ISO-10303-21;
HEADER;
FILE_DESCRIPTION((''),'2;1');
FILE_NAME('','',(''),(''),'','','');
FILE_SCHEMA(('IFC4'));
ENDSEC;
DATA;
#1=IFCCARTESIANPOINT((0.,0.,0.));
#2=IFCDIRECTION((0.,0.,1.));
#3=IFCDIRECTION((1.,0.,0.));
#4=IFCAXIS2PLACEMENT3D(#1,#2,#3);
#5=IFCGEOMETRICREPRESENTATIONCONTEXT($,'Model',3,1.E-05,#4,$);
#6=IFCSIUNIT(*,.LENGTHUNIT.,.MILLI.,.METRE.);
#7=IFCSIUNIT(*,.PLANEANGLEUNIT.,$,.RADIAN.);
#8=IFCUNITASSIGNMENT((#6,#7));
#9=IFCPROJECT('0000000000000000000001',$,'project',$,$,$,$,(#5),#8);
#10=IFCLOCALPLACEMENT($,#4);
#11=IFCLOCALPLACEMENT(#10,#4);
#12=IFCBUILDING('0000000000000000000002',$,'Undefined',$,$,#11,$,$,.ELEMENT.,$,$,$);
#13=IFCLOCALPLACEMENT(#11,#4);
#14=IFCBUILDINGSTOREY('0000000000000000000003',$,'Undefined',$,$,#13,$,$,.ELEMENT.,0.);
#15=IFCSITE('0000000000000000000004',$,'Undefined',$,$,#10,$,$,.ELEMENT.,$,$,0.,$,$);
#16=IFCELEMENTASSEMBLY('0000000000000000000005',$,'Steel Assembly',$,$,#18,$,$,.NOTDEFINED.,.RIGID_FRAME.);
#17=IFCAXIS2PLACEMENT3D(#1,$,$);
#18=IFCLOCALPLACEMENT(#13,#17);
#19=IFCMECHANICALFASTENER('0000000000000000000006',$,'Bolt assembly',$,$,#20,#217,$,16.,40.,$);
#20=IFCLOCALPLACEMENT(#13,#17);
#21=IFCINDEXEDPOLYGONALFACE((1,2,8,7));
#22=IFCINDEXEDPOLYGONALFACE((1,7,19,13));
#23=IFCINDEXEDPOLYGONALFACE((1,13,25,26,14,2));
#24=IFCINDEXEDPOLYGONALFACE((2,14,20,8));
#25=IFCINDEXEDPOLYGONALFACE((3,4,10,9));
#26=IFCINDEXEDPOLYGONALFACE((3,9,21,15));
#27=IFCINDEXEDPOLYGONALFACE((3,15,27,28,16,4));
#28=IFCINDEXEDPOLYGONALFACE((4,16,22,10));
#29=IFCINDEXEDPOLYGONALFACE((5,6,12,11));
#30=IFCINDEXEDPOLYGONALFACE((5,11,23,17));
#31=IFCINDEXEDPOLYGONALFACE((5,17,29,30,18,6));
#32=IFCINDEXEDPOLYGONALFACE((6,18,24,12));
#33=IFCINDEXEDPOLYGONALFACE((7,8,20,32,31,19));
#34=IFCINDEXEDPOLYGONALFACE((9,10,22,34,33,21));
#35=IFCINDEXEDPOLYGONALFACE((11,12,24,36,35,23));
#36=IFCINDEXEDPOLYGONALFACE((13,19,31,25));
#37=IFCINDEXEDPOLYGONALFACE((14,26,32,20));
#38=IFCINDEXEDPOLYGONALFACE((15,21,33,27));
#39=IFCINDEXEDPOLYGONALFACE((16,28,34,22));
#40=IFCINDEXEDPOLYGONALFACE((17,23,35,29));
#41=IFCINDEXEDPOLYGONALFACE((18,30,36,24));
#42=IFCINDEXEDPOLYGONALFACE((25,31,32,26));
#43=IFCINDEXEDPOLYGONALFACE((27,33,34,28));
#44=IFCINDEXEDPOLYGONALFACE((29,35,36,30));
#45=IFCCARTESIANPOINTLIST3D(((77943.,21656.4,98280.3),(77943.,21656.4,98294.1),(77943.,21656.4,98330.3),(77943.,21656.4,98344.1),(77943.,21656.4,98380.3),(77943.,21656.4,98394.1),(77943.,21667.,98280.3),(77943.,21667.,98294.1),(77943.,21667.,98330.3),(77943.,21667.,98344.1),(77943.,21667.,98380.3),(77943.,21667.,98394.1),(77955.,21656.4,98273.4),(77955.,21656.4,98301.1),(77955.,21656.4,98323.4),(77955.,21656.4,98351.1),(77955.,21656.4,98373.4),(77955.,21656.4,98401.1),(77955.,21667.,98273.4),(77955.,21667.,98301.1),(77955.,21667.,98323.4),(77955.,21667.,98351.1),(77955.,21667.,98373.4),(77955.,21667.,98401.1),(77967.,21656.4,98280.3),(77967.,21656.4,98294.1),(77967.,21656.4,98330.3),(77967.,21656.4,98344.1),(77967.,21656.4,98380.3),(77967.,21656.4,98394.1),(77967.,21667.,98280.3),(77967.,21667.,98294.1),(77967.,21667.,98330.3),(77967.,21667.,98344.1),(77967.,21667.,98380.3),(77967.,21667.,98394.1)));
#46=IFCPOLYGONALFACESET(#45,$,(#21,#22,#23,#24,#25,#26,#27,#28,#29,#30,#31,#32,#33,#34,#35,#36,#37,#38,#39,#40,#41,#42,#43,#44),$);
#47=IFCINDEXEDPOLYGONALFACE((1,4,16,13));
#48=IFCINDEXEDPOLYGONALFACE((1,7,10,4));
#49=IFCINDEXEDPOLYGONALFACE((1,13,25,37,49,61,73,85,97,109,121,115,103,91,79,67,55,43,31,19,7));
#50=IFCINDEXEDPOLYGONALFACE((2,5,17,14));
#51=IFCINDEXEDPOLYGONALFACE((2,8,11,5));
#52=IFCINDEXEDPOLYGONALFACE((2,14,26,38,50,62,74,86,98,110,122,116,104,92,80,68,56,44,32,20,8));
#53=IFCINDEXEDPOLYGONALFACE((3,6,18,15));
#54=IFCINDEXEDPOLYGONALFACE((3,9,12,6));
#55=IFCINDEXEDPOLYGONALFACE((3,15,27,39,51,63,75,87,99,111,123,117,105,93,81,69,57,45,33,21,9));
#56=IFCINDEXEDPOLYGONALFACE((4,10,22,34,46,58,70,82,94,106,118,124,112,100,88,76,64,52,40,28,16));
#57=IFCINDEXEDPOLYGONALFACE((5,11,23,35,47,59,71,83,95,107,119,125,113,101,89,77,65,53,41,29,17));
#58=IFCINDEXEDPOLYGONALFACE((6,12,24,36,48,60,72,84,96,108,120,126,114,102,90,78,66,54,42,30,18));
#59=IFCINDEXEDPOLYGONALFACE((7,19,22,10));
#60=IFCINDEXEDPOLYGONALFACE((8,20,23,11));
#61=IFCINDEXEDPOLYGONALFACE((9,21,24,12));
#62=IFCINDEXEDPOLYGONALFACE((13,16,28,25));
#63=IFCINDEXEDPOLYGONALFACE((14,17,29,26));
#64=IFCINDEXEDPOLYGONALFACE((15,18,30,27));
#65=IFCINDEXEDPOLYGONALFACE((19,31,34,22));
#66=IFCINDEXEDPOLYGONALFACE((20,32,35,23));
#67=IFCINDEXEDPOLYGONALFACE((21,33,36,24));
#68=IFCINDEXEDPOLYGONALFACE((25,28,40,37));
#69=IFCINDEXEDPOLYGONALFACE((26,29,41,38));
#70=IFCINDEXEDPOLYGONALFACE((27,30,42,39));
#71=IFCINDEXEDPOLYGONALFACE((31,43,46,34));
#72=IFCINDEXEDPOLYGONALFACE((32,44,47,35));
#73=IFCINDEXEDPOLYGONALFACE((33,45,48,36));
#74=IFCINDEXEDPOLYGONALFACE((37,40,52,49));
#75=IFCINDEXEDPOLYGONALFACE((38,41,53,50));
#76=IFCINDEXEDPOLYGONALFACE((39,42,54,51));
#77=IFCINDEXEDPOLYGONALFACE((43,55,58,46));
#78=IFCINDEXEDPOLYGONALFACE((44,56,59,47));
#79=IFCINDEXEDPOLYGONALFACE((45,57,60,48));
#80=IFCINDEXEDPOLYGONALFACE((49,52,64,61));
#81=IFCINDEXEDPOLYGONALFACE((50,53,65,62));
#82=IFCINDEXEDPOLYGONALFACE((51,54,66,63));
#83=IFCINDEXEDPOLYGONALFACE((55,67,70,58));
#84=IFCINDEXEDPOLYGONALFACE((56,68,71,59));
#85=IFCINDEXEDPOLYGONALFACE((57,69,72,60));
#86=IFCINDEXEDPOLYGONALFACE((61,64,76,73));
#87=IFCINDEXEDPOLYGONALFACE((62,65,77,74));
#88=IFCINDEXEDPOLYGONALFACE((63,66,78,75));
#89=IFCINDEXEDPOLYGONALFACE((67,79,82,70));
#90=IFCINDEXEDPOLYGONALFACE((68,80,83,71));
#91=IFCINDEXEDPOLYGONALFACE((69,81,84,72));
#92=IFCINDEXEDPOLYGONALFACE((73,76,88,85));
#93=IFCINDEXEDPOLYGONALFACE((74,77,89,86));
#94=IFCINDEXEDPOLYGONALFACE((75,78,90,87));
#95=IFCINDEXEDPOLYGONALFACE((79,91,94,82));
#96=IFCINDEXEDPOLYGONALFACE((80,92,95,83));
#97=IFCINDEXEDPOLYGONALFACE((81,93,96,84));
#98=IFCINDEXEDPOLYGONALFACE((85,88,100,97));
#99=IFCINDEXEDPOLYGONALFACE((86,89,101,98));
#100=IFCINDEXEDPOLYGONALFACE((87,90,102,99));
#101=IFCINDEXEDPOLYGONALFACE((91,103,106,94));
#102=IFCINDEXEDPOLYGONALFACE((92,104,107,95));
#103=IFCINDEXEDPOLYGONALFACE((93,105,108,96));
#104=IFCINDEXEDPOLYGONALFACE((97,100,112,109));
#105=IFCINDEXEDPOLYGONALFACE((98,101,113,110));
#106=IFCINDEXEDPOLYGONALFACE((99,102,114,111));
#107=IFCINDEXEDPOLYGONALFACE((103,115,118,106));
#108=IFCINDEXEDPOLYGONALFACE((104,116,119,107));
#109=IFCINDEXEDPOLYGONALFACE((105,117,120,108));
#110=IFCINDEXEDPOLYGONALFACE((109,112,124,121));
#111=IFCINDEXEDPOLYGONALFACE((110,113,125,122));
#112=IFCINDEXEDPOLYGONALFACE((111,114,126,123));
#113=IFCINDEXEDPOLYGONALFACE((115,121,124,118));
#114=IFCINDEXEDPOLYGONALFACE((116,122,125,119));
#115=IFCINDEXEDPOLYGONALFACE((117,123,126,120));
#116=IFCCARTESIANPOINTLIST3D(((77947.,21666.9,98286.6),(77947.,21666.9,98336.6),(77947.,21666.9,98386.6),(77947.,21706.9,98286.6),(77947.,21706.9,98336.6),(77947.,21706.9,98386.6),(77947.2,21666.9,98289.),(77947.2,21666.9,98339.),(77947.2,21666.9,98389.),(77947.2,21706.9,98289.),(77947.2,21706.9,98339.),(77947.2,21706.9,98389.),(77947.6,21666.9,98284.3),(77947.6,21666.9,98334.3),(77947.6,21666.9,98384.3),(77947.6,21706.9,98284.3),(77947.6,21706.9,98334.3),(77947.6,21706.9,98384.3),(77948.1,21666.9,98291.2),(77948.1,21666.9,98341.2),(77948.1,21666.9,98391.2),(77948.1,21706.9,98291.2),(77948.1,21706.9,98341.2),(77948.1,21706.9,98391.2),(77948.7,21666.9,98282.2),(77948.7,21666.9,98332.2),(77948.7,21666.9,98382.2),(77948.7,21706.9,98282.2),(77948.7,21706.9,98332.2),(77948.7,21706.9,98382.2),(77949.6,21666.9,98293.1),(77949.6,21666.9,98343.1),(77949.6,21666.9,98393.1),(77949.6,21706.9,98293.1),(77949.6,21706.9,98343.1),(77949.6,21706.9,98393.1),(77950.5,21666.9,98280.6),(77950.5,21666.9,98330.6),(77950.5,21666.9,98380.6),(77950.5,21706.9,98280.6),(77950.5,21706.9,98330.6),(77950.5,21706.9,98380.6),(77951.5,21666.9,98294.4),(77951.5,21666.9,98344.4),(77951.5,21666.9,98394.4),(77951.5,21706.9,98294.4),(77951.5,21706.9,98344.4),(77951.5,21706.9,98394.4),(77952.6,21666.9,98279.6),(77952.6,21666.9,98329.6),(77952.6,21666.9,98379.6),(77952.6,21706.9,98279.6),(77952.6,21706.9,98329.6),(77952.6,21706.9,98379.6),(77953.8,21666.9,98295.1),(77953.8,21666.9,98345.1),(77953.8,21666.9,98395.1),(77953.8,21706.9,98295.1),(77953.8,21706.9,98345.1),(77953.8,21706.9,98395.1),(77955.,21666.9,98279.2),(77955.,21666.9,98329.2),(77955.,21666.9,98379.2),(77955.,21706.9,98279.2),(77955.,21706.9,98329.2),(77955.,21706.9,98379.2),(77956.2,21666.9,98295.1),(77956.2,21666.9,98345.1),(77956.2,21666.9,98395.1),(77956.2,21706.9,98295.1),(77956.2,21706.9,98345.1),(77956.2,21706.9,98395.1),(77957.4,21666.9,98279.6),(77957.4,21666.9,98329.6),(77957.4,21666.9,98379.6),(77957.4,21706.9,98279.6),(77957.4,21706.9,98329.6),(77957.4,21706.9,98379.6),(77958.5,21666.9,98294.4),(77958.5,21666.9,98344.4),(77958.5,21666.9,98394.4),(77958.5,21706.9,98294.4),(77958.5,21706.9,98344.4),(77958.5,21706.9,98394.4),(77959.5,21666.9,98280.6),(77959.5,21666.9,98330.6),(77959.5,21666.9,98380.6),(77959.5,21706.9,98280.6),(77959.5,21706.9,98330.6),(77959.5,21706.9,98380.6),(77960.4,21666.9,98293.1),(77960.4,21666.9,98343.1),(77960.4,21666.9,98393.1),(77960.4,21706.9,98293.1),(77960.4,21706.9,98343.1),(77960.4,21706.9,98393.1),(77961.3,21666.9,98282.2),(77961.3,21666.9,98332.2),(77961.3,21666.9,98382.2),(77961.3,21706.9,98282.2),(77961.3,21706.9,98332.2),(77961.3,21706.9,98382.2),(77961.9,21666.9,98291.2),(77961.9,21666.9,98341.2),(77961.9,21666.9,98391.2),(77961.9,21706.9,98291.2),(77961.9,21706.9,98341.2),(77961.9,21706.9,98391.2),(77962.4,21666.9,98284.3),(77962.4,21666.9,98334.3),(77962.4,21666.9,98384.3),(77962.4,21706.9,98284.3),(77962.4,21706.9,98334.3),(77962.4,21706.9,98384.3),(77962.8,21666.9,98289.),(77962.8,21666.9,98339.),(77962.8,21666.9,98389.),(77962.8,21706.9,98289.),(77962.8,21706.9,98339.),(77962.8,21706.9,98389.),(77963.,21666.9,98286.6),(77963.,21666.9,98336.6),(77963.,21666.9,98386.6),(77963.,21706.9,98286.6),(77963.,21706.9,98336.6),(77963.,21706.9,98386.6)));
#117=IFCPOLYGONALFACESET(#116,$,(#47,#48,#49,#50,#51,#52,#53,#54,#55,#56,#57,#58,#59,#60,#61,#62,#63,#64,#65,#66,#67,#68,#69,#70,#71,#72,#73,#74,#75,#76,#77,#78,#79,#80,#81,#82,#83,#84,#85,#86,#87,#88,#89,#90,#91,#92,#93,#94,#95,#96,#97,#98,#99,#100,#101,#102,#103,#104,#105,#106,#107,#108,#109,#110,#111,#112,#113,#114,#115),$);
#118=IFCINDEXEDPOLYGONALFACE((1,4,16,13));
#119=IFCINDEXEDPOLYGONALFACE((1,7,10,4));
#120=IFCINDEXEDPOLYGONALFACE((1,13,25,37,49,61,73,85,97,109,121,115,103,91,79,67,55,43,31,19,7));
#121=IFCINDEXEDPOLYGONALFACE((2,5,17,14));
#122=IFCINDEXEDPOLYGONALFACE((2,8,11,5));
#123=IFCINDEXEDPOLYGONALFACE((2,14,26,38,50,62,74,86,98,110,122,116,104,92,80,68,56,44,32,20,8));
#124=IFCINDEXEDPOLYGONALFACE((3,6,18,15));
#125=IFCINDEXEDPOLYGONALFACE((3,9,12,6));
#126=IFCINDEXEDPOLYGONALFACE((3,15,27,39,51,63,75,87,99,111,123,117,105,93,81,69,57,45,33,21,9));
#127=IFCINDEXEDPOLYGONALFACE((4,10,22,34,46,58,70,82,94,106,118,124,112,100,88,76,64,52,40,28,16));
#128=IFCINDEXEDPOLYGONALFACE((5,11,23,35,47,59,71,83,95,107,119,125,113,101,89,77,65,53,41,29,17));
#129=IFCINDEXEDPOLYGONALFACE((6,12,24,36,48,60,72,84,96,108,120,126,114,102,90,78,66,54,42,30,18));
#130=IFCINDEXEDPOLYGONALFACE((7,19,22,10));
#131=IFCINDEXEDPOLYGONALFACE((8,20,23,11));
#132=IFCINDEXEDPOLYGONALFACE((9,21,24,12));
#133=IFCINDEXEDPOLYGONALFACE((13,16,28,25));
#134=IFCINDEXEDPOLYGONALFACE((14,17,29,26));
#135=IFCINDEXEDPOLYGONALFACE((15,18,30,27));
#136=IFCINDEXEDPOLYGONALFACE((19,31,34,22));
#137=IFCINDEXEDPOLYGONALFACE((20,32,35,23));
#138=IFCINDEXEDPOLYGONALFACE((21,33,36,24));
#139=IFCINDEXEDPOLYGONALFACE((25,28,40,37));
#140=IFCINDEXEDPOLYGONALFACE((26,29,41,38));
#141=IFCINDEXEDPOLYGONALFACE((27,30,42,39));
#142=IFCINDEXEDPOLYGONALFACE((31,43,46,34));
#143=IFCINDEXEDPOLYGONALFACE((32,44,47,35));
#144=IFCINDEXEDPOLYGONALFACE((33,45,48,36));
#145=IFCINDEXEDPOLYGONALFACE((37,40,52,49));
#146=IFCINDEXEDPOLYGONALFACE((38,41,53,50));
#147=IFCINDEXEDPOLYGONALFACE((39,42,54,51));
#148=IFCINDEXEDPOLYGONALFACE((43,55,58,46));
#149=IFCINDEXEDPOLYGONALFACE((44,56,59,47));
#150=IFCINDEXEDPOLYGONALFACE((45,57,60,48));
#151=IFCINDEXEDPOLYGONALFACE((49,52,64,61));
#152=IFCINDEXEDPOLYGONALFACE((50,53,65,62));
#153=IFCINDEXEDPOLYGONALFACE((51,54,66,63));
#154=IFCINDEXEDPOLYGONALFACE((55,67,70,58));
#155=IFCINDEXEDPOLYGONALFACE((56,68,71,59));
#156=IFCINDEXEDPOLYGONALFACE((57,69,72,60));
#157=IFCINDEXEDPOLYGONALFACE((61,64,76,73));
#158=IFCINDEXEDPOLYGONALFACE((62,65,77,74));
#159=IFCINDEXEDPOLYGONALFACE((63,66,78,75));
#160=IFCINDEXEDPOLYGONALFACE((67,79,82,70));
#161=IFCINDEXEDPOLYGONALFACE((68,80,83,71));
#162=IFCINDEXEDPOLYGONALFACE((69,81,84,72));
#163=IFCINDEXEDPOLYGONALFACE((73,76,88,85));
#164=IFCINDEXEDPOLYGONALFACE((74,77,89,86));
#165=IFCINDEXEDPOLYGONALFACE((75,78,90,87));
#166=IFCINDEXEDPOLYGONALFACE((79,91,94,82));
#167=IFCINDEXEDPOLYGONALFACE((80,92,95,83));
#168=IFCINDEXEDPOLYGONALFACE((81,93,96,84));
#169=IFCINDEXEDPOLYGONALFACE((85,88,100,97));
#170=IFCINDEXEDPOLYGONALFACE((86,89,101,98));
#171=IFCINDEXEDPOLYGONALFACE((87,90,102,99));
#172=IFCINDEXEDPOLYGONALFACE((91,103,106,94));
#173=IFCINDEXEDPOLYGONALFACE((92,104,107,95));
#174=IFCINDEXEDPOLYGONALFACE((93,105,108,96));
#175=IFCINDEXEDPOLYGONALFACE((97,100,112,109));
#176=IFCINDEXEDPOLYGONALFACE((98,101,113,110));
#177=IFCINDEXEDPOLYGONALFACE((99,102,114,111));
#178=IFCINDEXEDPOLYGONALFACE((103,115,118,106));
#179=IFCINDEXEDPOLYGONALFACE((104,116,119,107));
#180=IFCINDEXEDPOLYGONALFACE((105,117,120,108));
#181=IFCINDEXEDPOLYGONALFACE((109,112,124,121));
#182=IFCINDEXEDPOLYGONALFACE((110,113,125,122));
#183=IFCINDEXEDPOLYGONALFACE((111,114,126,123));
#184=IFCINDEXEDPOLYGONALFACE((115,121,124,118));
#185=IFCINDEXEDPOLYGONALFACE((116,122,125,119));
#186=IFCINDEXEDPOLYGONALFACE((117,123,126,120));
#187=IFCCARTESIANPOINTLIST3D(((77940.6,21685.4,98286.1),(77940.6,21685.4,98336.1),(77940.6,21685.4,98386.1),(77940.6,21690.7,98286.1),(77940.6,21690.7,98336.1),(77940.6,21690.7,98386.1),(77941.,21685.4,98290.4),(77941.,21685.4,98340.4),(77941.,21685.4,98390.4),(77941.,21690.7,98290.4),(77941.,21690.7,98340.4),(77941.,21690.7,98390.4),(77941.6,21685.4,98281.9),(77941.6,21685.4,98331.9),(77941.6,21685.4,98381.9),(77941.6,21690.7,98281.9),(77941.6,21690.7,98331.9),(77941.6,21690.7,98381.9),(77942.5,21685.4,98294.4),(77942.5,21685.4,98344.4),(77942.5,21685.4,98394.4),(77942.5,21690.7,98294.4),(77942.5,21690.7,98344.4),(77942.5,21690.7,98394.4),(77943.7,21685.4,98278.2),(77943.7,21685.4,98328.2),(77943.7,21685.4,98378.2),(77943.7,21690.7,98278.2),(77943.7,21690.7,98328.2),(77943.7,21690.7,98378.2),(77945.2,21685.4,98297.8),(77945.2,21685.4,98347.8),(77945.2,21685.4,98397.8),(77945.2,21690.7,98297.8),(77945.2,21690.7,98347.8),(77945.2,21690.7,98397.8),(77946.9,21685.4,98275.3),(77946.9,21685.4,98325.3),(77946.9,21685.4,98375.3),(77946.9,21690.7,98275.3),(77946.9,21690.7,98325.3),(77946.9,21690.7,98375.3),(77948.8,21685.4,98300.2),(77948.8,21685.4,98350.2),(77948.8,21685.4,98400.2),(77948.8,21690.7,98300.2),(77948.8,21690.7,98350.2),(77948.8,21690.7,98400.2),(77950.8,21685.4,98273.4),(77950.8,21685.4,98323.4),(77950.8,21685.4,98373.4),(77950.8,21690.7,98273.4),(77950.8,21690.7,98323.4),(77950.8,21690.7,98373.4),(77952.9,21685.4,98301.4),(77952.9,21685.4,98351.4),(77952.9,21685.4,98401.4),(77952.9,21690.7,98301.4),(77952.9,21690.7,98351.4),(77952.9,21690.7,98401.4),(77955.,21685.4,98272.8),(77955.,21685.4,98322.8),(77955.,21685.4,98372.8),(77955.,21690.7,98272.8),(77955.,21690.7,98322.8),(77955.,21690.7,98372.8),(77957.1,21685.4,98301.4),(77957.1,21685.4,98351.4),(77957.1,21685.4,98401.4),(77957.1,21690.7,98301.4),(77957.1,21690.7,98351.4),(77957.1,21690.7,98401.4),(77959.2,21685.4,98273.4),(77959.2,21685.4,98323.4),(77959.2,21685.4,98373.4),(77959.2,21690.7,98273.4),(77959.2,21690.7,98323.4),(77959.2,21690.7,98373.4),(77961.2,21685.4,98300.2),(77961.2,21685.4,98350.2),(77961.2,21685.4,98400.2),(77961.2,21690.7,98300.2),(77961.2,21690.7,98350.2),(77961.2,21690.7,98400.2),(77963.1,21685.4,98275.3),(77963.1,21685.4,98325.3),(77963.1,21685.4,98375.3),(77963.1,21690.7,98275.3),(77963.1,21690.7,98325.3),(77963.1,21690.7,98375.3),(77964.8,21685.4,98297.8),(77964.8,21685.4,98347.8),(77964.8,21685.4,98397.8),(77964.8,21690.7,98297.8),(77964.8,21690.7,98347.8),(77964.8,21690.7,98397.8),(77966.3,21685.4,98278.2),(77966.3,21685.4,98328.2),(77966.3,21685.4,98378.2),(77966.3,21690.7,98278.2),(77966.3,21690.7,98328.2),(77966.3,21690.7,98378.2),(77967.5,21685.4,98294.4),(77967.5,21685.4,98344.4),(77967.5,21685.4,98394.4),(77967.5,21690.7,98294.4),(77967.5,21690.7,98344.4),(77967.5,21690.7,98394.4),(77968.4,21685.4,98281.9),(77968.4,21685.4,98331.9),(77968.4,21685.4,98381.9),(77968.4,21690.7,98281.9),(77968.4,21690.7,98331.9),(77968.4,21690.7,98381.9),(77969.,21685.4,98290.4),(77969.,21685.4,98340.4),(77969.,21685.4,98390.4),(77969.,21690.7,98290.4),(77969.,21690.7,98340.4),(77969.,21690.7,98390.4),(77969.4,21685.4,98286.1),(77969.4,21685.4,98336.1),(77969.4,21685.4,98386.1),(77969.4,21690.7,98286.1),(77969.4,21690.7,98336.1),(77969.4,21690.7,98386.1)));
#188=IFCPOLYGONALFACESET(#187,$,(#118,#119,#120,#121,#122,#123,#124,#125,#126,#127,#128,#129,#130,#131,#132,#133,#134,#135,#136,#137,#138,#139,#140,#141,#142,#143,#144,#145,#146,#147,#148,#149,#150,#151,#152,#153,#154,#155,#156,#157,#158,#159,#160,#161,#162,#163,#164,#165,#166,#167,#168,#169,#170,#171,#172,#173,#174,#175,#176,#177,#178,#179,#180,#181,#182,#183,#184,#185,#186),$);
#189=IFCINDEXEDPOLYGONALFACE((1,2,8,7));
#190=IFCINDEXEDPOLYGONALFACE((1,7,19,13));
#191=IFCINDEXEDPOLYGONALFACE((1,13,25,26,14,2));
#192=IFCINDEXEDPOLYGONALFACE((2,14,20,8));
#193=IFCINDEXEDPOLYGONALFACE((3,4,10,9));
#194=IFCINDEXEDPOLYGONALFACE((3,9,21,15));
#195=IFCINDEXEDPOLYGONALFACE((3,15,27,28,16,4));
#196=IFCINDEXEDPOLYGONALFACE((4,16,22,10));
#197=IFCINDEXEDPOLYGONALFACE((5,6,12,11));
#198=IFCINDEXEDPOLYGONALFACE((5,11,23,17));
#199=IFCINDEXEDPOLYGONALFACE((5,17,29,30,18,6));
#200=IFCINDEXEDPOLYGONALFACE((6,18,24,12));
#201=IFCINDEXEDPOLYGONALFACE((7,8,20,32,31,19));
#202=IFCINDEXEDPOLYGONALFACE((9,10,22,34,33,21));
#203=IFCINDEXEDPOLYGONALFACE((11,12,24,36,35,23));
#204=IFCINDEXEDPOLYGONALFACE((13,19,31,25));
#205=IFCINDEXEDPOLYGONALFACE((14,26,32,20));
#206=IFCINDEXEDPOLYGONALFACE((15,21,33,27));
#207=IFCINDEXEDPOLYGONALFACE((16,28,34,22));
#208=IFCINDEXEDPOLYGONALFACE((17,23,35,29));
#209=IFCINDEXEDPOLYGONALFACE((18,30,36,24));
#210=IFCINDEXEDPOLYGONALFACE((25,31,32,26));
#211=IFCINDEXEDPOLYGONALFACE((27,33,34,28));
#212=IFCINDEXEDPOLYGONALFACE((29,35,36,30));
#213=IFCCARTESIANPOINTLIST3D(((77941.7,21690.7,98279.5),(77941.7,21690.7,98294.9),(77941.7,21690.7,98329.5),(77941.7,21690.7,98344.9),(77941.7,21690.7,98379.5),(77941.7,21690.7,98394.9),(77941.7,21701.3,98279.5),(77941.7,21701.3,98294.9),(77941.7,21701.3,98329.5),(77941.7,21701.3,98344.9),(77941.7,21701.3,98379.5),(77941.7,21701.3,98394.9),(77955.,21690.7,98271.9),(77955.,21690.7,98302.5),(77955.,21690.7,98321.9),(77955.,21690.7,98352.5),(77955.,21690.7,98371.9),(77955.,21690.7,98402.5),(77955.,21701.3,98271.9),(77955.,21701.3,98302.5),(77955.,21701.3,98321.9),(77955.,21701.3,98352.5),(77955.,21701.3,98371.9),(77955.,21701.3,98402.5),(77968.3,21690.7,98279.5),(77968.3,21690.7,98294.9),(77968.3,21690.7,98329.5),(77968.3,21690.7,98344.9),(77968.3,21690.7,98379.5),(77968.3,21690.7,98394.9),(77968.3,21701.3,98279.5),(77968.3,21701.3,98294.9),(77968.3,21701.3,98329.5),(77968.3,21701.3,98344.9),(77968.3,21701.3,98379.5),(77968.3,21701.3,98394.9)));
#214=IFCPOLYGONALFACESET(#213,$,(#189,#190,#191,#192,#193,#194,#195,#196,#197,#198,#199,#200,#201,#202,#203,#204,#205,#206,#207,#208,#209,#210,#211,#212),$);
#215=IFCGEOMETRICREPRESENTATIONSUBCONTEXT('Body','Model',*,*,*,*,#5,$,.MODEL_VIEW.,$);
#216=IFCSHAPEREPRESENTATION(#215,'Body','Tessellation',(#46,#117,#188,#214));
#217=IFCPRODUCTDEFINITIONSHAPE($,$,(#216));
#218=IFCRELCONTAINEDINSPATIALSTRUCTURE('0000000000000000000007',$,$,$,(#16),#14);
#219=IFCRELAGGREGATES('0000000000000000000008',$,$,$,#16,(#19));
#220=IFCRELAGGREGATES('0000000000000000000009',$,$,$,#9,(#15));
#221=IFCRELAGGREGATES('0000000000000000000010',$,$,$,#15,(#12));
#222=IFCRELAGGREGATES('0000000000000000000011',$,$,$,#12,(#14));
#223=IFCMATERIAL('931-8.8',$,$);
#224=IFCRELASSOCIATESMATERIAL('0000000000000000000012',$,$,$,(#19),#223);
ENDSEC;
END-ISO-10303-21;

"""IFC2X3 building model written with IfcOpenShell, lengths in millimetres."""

from ifc_helpers import new_model, si_unit, frame, origin_with_axes, origin_2d_with_axis, place, context, subcontext, project, spatial, polyline, circle, outline, extrude, source, transform, mapped, material, element, aggregate, save


model = new_model("IFC2X3")

# Units and contexts
model_context = context("Model", 3, precision=1e-05, world=origin_with_axes())
body_context = subcontext(model_context, "Body", "Model", "MODEL_VIEW")
ifc_project = project(units=[si_unit("LENGTHUNIT", "METRE", prefix="MILLI"), si_unit("PLANEANGLEUNIT", "RADIAN")], contexts=[model_context])

# Site, building, storey
site_placement = place(None, origin_with_axes())
site = spatial("IfcSite", under=ifc_project, at=site_placement, Name="Undefined", CompositionType="ELEMENT", RefElevation=0.0)
building_placement = place(site_placement, origin_with_axes())
building = spatial("IfcBuilding", under=site, at=building_placement, Name="Undefined", CompositionType="ELEMENT")
storey_placement = place(building_placement, origin_with_axes())
storey = spatial("IfcBuildingStorey", under=building, at=storey_placement, Name="Undefined", CompositionType="ELEMENT", Elevation=0.0)

# Shared definitions
ifc_material_1 = material(Name="931-8.8")

# Element assembly, mechanical fastener
assembly_1_placement = place(storey_placement, origin_with_axes())
assembly_1 = element("IfcElementAssembly", 1, at=assembly_1_placement, inside=storey, Name="Steel Assembly", AssemblyPlace="NOTDEFINED", PredefinedType="RIGID_FRAME")
shared_shape_1 = source(origin_with_axes(), body_context, "Body", "SweptSolid", [
    extrude(outline(polyline([(13.9, 0.0), (6.9, 12.0), (-6.9, 12.0), (-13.9, 0.0), (-6.9, -12.0), (6.9, -12.0), (13.9, 0.0)])), frame((0.0, -19.1, 0.0), z_axis=(0.0, 1.0, 0.0), x_axis=(1.0, 0.0, 0.0)), (0.0, 0.0, 1.0), 10.6),
    extrude(circle(Radius=8.0, at=origin_2d_with_axis()), frame((0.0, -8.5, 0.0), z_axis=(0.0, 1.0, 0.0), x_axis=(1.0, 0.0, 0.0)), (0.0, 0.0, 1.0), 40.0),
    extrude(circle(Radius=14.4, at=origin_2d_with_axis()), frame((0.0, 10.0, 0.0), z_axis=(0.0, 1.0, 0.0), x_axis=(1.0, 0.0, 0.0)), (0.0, 0.0, 1.0), 5.3),
    extrude(outline(polyline([(15.3, 0.0), (7.7, 13.3), (-7.7, 13.3), (-15.3, 0.0), (-7.7, -13.3), (7.7, -13.3), (15.3, 0.0)])), frame((0.0, 15.3, 0.0), z_axis=(0.0, 1.0, 0.0), x_axis=(1.0, 0.0, 0.0)), (0.0, 0.0, 1.0), 10.6),
])
mechanical_fastener_1_placement = place(assembly_1_placement, frame((77955.0, 21675.4, 98387.2), z_axis=(1.0, 0.0, 0.0), x_axis=(0.0, 0.0, -1.0)))
mechanical_fastener_1 = element("IfcMechanicalFastener", 2, at=mechanical_fastener_1_placement, material=ifc_material_1, Name="Bolt assembly", NominalDiameter=16.0, NominalLength=40.0, context=body_context, shape_type="MappedRepresentation", body=[
    mapped(shared_shape_1, transform((0.0, 0.0, 0.0))),
    mapped(shared_shape_1, transform((50.0, 0.0, 0.0))),
    mapped(shared_shape_1, transform((100.0, 0.0, 0.0))),
])
aggregate(assembly_1, [mechanical_fastener_1])

save(model, "model.ifc")
